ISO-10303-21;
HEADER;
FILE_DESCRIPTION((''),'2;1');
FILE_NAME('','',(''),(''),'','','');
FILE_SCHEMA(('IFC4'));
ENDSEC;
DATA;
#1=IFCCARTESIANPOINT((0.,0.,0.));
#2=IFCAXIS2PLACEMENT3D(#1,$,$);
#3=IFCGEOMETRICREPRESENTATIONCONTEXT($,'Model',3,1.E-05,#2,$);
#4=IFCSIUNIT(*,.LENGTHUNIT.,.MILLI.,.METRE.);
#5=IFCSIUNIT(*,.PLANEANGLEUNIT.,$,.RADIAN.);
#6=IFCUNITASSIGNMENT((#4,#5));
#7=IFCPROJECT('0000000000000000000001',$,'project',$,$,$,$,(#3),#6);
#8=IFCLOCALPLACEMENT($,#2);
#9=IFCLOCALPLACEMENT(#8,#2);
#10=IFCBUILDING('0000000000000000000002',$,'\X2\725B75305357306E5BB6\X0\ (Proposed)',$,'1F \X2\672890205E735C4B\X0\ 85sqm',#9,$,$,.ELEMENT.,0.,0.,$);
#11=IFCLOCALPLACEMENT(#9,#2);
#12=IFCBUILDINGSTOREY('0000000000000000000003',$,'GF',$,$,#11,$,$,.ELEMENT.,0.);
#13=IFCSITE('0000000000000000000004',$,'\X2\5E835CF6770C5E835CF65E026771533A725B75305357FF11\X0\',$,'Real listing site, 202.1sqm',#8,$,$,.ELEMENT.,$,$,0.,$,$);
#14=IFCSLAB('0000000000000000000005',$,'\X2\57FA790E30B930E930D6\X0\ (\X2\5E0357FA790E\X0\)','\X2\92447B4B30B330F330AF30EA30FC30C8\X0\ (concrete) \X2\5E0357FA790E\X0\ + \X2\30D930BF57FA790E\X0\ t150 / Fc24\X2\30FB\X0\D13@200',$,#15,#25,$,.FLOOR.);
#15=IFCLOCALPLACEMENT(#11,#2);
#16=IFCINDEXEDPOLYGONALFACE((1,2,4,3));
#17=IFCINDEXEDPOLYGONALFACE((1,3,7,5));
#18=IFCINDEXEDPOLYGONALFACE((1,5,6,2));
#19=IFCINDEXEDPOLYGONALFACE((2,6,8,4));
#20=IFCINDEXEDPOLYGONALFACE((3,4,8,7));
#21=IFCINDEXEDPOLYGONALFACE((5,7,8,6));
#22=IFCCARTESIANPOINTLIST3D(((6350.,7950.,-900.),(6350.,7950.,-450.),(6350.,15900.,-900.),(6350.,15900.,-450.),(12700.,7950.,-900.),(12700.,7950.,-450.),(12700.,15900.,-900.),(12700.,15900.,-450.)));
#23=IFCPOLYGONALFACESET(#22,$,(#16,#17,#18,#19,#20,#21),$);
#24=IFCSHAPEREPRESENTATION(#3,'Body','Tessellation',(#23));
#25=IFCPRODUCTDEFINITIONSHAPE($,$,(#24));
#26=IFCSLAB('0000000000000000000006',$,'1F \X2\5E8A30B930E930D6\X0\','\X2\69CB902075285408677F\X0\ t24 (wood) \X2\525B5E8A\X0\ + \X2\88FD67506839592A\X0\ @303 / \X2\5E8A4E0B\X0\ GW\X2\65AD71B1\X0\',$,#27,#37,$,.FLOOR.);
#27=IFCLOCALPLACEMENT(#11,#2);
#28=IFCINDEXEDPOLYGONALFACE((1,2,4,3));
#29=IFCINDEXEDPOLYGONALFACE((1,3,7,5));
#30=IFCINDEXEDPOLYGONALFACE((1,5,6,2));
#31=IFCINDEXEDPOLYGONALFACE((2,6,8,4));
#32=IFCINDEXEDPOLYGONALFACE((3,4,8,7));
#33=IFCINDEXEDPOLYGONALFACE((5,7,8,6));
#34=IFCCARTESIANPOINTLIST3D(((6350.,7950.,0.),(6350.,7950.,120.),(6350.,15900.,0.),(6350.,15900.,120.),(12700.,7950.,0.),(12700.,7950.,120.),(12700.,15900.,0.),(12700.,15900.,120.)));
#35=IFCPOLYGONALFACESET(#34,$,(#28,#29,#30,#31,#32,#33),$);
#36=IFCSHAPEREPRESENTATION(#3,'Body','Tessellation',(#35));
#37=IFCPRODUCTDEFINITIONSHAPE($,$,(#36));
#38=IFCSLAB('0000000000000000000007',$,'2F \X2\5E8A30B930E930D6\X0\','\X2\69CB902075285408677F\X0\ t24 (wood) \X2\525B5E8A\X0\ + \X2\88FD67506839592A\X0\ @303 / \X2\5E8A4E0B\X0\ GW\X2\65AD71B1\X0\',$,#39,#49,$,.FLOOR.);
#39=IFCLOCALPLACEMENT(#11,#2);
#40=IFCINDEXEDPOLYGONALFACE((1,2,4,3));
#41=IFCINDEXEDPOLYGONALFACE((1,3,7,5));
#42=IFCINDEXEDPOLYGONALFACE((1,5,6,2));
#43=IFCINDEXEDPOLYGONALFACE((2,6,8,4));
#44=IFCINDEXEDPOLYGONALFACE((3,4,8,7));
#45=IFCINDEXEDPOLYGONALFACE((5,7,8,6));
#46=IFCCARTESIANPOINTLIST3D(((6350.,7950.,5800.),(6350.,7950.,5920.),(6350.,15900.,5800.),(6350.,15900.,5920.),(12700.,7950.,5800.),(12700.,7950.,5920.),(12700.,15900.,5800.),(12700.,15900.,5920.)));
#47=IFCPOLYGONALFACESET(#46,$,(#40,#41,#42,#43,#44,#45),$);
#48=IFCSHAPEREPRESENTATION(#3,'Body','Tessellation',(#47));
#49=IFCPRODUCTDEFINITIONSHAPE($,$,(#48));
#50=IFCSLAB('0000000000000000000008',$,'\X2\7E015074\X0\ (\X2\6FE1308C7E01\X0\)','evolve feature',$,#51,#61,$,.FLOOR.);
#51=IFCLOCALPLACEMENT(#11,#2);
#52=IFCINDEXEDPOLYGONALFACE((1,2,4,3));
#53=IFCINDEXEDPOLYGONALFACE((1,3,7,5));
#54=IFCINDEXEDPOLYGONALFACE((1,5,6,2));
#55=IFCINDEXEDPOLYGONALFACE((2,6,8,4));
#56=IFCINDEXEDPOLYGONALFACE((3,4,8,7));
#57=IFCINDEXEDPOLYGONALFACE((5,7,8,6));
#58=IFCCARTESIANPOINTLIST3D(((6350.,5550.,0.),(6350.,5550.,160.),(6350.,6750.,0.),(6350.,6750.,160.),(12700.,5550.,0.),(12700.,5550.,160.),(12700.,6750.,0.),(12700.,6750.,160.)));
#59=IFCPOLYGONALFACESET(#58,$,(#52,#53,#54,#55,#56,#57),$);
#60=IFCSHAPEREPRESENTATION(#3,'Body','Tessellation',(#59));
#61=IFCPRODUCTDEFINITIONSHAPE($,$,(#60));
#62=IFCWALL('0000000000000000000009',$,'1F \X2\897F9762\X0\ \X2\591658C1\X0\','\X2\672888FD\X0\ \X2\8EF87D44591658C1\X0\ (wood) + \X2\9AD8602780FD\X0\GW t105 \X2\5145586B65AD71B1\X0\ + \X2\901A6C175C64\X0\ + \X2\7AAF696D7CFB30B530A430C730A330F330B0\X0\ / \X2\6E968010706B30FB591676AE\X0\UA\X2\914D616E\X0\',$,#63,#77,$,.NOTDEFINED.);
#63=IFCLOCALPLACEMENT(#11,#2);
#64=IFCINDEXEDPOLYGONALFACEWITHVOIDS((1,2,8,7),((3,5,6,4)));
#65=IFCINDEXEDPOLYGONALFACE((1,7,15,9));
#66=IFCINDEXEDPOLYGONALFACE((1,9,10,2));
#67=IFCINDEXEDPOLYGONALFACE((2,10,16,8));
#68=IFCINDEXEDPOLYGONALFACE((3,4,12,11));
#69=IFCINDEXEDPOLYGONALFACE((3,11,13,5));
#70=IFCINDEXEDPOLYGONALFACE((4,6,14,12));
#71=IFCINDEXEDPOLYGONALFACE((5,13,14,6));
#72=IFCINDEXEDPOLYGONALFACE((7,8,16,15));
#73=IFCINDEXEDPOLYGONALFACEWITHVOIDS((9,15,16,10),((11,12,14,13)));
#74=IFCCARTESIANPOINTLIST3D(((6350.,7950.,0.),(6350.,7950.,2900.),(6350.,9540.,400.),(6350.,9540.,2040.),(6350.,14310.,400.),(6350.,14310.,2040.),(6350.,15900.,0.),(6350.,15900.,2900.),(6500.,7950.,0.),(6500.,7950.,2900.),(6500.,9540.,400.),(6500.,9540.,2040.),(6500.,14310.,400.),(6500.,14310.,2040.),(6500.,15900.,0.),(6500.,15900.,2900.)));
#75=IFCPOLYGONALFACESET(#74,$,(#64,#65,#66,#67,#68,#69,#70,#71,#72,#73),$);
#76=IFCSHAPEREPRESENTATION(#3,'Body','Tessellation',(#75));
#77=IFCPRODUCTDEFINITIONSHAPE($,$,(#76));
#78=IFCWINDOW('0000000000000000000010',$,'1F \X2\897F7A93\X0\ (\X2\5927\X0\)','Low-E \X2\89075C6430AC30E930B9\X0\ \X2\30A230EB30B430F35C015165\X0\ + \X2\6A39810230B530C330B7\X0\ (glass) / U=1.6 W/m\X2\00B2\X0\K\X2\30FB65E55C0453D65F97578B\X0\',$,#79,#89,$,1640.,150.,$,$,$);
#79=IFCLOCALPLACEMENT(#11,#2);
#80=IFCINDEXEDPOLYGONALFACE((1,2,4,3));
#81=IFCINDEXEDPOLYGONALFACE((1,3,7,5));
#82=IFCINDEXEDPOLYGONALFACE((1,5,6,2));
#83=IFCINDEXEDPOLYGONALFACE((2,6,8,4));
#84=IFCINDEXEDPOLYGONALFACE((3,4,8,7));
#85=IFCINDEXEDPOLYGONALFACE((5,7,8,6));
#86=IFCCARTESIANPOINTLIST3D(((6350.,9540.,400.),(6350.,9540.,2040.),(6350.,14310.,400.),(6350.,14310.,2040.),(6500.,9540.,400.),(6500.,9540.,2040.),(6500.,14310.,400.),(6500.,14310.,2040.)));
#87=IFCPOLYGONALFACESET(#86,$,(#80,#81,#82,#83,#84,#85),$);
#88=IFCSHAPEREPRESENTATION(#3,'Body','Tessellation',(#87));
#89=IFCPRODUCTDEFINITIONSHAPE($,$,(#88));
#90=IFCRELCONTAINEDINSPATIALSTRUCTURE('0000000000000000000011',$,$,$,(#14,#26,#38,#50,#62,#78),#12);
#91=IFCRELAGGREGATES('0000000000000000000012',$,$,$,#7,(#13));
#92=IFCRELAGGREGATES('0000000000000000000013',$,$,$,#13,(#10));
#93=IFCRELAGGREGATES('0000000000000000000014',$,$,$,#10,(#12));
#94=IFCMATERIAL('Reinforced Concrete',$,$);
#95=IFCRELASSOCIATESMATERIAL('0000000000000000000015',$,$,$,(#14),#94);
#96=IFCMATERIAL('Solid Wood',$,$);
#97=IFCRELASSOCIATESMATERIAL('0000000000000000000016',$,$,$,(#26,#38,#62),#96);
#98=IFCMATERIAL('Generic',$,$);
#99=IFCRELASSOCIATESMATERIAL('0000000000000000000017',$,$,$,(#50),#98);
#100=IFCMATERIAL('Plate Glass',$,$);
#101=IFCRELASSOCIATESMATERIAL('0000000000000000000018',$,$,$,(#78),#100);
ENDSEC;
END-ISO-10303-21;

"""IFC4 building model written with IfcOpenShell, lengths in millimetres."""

from ifc_helpers import new_model, si_unit, frame, frame_2d, origin, place, context, project, spatial, rectangle, extrude, material, element, fill, save


model = new_model("IFC4")

# Units and contexts
model_context = context("Model", 3, precision=1e-05, world=origin())
ifc_project = project(units=[si_unit("LENGTHUNIT", "METRE", prefix="MILLI"), si_unit("PLANEANGLEUNIT", "RADIAN")], contexts=[model_context])

# Site, building, storey
site_placement = place(None, origin())
site = spatial("IfcSite", under=ifc_project, at=site_placement, Name="広島県広島市東区牛田南１", ObjectType="Real listing site, 202.1sqm", CompositionType="ELEMENT", RefElevation=0.0)
building_placement = place(site_placement, origin())
building = spatial("IfcBuilding", under=site, at=building_placement, Name="牛田南の家 (Proposed)", ObjectType="1F 木造平屋 85sqm", CompositionType="ELEMENT", ElevationOfRefHeight=0.0, ElevationOfTerrain=0.0)
storey_placement = place(building_placement, origin())
storey = spatial("IfcBuildingStorey", under=building, at=storey_placement, Name="GF", CompositionType="ELEMENT", Elevation=0.0)

# Slabs
ifc_material_1 = material(Name="Reinforced Concrete")
slab_1_placement = place(storey_placement, frame((3175.0, 3975.0, -450.0)))
element("IfcSlab", 1, at=slab_1_placement, inside=storey, material=ifc_material_1, Name="基礎スラブ (布基礎)", Description="鉄筋コンクリート (concrete) 布基礎 + ベタ基礎 t150 / Fc24・D13@200", PredefinedType="FLOOR", context=model_context, shape_type="SweptSolid", body=[
    extrude(rectangle(XDim=6350.0, YDim=7950.0, at=frame_2d((3175.0, 3975.0))), frame((3175.0, 3975.0, -450.0)), (0.0, 0.0, 1.0), 450.0),
])
ifc_material_2 = material(Name="Solid Wood")
slab_2_placement = place(storey_placement, frame((3175.0, 3975.0, 0.0)))
element("IfcSlab", 2, at=slab_2_placement, inside=storey, material=ifc_material_2, Name="1F 床スラブ", Description="構造用合板 t24 (wood) 剛床 + 製材根太 @303 / 床下 GW断熱", PredefinedType="FLOOR", context=model_context, shape_type="SweptSolid", body=[
    extrude(rectangle(XDim=6350.0, YDim=7950.0, at=frame_2d((3175.0, 3975.0))), frame((3175.0, 3975.0, 0.0)), (0.0, 0.0, 1.0), 120.0),
])
slab_3_placement = place(storey_placement, frame((3175.0, 3975.0, 2900.0)))
element("IfcSlab", 3, at=slab_3_placement, inside=storey, material=ifc_material_2, Name="2F 床スラブ", Description="構造用合板 t24 (wood) 剛床 + 製材根太 @303 / 床下 GW断熱", PredefinedType="FLOOR", context=model_context, shape_type="SweptSolid", body=[
    extrude(rectangle(XDim=6350.0, YDim=7950.0, at=frame_2d((3175.0, 3975.0))), frame((3175.0, 3975.0, 2900.0)), (0.0, 0.0, 1.0), 120.0),
])
ifc_material_3 = material(Name="Generic")
slab_4_placement = place(storey_placement, frame((3175.0, 2775.0, 0.0)))
element("IfcSlab", 4, at=slab_4_placement, inside=storey, material=ifc_material_3, Name="縁側 (濡れ縁)", Description="evolve feature", PredefinedType="FLOOR", context=model_context, shape_type="SweptSolid", body=[
    extrude(rectangle(XDim=6350.0, YDim=1200.0, at=frame_2d((3175.0, 600.0))), frame((3175.0, 2775.0, 0.0)), (0.0, 0.0, 1.0), 160.0),
])

# Shared definitions
ifc_material_4 = material(Name="Plate Glass")

# Wall, opening, window
wall_1_placement = place(storey_placement, frame((3175.0, 3975.0, 0.0)))
wall_1 = element("IfcWall", 5, at=wall_1_placement, inside=storey, material=ifc_material_2, Name="1F 西面 外壁", Description="木製 軸組外壁 (wood) + 高性能GW t105 充填断熱 + 通気層 + 窯業系サイディング / 準耐火・外皮UA配慮", PredefinedType="NOTDEFINED", context=model_context, shape_type="SweptSolid", body=[
    extrude(rectangle(XDim=150.0, YDim=7950.0, at=frame_2d((75.0, 3975.0))), frame((3175.0, 3975.0, 0.0)), (0.0, 0.0, 1.0), 2900.0),
])
opening_1_placement = place(storey_placement, frame((3175.0, 4770.0, 200.0)))
opening_1 = element("IfcOpeningElement", 6, at=opening_1_placement, cuts=wall_1, PredefinedType="NOTDEFINED", context=model_context, shape_type="SweptSolid", body=[
    extrude(rectangle(XDim=150.0, YDim=4770.0, at=frame_2d((75.0, 2385.0))), frame((3175.0, 4770.0, 200.0)), (0.0, 0.0, 1.0), 1640.0),
])
window_1_placement = place(storey_placement, frame((3175.0, 4770.0, 200.0)))
window_1 = element("IfcWindow", 7, at=window_1_placement, inside=storey, material=ifc_material_4, Name="1F 西窓 (大)", Description="Low-E 複層ガラス アルゴン封入 + 樹脂サッシ (glass) / U=1.6 W/m²K・日射取得型", OverallHeight=1640.0, OverallWidth=150.0, context=model_context, shape_type="SweptSolid", body=[
    extrude(rectangle(XDim=150.0, YDim=4770.0, at=frame_2d((75.0, 2385.0))), frame((3175.0, 4770.0, 200.0)), (0.0, 0.0, 1.0), 1640.0),
])
fill(opening_1, window_1)

save(model, "model.ifc")
